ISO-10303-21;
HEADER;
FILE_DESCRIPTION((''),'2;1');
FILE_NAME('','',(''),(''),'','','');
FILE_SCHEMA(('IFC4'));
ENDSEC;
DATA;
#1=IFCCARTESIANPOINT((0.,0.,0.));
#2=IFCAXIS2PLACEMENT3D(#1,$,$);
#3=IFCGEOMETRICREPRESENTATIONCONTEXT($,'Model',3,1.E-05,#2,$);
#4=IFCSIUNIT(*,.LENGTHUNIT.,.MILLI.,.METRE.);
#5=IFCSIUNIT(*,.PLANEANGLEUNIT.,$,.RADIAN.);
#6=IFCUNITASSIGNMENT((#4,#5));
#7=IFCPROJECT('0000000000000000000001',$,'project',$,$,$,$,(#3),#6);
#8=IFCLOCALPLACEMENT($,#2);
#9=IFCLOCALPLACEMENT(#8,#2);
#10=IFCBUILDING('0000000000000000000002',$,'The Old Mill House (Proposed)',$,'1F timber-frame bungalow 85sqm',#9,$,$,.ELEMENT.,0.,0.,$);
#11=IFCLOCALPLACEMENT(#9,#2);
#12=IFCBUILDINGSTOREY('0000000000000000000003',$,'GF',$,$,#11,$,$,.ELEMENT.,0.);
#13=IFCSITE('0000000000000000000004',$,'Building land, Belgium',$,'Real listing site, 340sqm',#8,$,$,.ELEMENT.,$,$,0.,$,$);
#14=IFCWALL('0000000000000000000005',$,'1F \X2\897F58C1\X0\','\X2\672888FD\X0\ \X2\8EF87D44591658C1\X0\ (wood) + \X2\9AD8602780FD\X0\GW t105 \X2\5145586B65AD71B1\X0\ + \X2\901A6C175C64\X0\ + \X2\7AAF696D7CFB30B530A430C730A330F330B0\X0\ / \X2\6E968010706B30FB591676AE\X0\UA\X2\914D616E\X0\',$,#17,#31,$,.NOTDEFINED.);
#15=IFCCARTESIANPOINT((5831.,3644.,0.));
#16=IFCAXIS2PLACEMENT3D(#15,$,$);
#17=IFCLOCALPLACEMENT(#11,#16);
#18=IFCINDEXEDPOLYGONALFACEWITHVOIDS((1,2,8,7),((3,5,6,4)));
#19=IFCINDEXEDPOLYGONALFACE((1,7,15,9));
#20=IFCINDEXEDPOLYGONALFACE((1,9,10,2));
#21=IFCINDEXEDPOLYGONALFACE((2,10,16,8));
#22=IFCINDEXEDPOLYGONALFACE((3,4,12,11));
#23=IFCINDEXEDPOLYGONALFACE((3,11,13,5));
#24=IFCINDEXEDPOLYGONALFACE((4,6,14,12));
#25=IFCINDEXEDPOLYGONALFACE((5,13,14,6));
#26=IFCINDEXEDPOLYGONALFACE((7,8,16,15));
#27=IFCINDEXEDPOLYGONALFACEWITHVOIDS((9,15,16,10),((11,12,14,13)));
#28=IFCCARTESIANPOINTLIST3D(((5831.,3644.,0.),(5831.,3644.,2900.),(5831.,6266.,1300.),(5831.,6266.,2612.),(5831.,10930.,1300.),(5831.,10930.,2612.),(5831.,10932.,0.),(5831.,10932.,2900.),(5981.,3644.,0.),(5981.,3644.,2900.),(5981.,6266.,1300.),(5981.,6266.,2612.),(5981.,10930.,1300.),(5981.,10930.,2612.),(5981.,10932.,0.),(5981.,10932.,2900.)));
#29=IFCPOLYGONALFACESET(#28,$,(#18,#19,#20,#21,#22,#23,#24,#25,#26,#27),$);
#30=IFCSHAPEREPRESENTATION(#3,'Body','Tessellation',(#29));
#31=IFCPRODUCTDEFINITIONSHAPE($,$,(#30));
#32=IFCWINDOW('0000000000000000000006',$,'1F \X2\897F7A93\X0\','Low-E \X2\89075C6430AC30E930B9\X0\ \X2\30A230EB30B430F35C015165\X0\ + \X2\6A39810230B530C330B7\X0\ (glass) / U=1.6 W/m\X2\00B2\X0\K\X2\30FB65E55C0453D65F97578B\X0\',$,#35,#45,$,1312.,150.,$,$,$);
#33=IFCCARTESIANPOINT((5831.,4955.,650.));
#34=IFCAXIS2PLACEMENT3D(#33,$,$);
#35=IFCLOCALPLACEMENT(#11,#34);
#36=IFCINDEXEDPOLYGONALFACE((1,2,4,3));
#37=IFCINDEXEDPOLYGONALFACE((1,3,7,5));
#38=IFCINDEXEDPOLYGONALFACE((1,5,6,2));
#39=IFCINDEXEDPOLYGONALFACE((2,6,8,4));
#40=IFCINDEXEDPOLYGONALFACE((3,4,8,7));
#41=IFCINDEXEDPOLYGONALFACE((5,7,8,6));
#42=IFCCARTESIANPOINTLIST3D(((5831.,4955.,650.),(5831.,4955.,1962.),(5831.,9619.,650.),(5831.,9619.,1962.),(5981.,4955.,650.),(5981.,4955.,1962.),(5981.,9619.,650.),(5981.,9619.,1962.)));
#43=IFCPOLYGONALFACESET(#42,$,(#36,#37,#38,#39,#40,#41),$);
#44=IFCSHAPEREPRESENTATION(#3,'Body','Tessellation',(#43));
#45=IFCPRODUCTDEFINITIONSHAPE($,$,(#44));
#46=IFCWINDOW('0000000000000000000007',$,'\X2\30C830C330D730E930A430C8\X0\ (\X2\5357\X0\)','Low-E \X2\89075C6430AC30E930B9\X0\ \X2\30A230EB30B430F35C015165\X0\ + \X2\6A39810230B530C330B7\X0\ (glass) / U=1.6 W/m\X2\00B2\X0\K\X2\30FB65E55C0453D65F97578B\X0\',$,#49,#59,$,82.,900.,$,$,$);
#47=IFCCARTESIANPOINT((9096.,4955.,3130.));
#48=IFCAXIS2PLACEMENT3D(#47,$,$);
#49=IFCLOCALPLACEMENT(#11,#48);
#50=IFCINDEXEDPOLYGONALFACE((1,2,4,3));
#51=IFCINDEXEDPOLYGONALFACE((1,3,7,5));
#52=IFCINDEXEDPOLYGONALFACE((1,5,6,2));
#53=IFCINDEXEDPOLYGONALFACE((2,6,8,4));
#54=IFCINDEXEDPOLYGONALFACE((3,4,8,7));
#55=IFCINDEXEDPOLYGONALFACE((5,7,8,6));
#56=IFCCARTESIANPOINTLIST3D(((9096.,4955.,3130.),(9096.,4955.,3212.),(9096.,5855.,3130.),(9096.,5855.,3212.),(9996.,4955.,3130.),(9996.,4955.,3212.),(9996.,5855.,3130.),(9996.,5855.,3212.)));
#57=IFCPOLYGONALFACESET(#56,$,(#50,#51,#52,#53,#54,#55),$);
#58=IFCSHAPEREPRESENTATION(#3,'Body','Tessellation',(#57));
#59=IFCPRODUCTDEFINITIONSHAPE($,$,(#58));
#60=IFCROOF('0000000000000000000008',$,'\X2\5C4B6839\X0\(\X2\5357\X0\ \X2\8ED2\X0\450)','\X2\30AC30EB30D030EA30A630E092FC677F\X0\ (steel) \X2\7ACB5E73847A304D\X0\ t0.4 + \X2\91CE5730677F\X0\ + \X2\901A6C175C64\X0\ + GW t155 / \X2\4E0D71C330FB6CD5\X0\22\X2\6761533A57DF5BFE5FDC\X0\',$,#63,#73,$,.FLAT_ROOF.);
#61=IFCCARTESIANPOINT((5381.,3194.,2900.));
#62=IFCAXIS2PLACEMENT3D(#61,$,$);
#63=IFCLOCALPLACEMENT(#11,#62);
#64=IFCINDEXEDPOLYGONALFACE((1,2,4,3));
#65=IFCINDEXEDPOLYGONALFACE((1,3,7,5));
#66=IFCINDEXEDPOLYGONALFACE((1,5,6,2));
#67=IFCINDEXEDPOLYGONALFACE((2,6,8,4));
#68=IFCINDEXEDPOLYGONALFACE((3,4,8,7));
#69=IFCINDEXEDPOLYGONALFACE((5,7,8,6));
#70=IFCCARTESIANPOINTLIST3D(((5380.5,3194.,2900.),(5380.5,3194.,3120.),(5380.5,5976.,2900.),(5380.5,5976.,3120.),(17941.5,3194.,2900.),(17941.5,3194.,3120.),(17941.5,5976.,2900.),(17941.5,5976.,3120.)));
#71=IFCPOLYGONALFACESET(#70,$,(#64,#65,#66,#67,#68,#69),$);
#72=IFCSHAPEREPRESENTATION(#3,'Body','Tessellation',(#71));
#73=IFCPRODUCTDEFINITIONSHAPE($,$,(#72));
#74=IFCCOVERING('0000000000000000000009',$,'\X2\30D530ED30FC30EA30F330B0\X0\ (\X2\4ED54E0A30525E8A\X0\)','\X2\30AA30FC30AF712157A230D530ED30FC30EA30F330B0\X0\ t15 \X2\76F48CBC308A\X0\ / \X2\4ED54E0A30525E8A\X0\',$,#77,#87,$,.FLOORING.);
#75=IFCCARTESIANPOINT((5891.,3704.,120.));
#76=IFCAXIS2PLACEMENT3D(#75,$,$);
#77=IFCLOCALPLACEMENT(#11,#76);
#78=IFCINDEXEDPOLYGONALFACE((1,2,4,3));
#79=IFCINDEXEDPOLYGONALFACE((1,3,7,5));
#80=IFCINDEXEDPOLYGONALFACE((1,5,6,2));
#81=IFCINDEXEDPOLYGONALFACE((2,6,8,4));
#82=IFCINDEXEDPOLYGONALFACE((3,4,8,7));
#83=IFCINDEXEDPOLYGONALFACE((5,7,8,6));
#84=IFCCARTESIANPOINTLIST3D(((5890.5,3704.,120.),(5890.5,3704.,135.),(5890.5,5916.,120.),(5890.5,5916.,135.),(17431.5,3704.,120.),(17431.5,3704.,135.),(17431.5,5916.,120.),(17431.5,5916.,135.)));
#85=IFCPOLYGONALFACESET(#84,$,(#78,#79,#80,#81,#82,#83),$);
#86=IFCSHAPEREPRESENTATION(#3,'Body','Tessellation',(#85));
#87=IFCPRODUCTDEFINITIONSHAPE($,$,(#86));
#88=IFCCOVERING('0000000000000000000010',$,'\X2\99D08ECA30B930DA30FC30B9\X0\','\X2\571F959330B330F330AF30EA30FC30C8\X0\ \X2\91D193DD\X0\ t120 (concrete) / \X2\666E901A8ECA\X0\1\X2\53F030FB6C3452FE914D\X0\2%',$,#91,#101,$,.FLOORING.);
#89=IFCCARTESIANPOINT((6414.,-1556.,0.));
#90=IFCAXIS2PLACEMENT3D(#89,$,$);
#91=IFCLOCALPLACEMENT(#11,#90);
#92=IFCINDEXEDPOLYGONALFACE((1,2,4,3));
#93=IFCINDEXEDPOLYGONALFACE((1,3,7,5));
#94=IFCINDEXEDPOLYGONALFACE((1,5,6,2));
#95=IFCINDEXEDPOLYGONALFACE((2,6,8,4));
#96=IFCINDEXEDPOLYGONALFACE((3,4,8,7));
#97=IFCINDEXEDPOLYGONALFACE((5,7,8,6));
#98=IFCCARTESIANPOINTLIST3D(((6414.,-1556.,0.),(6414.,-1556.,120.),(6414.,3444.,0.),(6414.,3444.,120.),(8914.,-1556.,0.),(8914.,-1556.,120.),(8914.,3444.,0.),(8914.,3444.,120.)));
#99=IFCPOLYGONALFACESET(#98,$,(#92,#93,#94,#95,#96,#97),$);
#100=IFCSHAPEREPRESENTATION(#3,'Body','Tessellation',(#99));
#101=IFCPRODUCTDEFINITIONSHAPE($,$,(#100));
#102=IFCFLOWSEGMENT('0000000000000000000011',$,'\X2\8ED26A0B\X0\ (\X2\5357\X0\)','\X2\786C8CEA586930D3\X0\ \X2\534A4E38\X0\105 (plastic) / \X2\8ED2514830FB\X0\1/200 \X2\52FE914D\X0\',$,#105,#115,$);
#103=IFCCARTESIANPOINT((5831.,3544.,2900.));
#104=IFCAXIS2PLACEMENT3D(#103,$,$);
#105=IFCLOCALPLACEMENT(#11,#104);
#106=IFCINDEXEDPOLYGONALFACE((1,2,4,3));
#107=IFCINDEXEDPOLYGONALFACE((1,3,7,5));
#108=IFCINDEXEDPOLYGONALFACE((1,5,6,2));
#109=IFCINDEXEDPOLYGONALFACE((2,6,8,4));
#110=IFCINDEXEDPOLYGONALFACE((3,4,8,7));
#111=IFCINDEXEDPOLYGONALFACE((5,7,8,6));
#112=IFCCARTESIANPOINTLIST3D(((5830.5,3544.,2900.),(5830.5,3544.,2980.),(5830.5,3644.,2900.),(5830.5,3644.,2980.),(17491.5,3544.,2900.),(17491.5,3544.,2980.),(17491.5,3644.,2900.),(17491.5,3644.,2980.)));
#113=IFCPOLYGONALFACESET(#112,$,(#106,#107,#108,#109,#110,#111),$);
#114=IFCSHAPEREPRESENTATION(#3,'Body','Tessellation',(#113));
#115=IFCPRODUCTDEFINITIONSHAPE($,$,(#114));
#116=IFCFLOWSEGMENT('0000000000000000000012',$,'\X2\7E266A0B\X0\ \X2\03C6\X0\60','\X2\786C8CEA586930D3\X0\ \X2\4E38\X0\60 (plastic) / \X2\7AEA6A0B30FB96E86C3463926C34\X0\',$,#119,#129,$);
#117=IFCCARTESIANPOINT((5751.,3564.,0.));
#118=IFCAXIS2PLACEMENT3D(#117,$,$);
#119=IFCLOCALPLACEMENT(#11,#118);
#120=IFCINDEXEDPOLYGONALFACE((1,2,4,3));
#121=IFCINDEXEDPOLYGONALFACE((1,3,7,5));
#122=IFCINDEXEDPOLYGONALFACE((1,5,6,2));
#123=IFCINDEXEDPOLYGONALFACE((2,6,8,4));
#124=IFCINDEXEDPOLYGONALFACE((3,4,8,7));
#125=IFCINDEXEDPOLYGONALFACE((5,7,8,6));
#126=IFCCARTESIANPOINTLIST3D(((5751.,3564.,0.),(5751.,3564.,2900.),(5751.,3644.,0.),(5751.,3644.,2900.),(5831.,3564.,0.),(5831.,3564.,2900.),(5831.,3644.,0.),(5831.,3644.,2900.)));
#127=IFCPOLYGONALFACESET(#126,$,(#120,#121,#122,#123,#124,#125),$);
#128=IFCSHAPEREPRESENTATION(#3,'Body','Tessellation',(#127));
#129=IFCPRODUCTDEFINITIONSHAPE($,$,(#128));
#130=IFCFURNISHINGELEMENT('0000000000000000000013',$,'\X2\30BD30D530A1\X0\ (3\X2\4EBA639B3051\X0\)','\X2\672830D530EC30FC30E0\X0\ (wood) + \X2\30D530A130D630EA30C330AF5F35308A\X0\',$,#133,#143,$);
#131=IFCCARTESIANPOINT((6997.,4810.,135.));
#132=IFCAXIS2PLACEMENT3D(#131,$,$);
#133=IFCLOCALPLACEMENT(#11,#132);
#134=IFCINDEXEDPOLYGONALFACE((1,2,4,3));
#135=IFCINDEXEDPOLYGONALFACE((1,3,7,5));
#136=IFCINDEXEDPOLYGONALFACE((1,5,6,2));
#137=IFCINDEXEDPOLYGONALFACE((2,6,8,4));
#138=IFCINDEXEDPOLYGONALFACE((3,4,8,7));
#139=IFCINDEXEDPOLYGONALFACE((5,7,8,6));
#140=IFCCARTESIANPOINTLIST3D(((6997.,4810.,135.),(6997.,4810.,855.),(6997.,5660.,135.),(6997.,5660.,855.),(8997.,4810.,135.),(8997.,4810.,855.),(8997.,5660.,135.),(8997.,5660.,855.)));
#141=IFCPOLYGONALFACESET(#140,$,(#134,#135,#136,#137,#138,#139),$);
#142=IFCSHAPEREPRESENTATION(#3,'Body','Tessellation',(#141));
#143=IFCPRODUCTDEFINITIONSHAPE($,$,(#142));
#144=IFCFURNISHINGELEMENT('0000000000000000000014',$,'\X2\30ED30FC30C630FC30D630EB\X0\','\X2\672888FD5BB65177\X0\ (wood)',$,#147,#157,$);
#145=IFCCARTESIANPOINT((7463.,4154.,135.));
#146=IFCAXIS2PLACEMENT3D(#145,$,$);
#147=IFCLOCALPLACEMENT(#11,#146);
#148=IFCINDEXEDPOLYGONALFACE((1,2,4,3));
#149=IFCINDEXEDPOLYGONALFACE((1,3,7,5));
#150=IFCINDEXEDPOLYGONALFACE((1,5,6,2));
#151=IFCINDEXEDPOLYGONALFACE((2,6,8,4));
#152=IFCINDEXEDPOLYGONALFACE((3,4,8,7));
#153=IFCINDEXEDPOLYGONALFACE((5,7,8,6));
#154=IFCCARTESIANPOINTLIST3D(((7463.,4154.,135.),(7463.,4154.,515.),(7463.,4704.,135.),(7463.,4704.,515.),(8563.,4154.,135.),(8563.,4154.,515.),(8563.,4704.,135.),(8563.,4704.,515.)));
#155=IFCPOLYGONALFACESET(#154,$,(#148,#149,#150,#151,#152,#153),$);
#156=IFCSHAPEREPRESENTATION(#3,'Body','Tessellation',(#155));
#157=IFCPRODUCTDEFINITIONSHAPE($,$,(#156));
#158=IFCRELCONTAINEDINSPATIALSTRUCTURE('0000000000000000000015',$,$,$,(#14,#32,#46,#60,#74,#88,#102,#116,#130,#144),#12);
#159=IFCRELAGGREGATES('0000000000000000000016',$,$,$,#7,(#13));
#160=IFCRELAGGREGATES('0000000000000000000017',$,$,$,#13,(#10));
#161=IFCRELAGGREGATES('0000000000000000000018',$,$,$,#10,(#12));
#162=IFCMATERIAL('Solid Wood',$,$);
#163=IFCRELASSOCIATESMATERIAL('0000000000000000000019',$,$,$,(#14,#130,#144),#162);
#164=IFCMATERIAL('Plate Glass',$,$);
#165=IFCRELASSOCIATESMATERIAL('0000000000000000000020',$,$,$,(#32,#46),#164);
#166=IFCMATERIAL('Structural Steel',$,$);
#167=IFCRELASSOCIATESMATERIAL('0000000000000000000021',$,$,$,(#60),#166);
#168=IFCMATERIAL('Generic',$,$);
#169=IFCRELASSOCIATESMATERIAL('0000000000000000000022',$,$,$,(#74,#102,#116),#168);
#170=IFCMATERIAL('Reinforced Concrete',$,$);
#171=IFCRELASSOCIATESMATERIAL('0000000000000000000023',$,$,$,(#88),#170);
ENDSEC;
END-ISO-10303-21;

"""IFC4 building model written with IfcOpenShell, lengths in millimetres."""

from ifc_helpers import new_model, si_unit, frame, frame_2d, origin, place, context, project, spatial, rectangle, extrude, material, element, fill, save


model = new_model("IFC4")

# Units and contexts
model_context = context("Model", 3, precision=1e-05, world=origin())
ifc_project = project(units=[si_unit("LENGTHUNIT", "METRE", prefix="MILLI"), si_unit("PLANEANGLEUNIT", "RADIAN")], contexts=[model_context])

# Site, building, storey
site_placement = place(None, origin())
site = spatial("IfcSite", under=ifc_project, at=site_placement, Name="Building land, Belgium", ObjectType="Real listing site, 340sqm", CompositionType="ELEMENT", RefElevation=0.0)
building_placement = place(site_placement, origin())
building = spatial("IfcBuilding", under=site, at=building_placement, Name="The Old Mill House (Proposed)", ObjectType="1F timber-frame bungalow 85sqm", CompositionType="ELEMENT", ElevationOfRefHeight=0.0, ElevationOfTerrain=0.0)
storey_placement = place(building_placement, origin())
storey = spatial("IfcBuildingStorey", under=building, at=storey_placement, Name="GF", CompositionType="ELEMENT", Elevation=0.0)

# Shared definitions
ifc_material_1 = material(Name="Solid Wood")

# Shared definitions
ifc_material_2 = material(Name="Reinforced Concrete")

# Shared definitions
ifc_material_3 = material(Name="Plate Glass")

# Wall, opening, window
wall_1_placement = place(storey_placement, frame((5831.0, 3644.0, 0.0)))
wall_1 = element("IfcWall", 1, at=wall_1_placement, inside=storey, material=ifc_material_1, Name="1F 西壁", Description="木製 軸組外壁 (wood) + 高性能GW t105 充填断熱 + 通気層 + 窯業系サイディング / 準耐火・外皮UA配慮", PredefinedType="NOTDEFINED", context=model_context, shape_type="SweptSolid", body=[
    extrude(rectangle(XDim=150.0, YDim=7288.0, at=frame_2d((75.0, 3644.0))), frame((5831.0, 3644.0, 0.0)), (0.0, 0.0, 1.0), 2900.0),
])
opening_1_placement = place(storey_placement, frame((5831.0, 4955.0, 650.0)))
opening_1 = element("IfcOpeningElement", 2, at=opening_1_placement, cuts=wall_1, PredefinedType="NOTDEFINED", context=model_context, shape_type="SweptSolid", body=[
    extrude(rectangle(XDim=150.0, YDim=4664.0, at=frame_2d((75.0, 2332.0))), frame((5831.0, 4955.0, 650.0)), (0.0, 0.0, 1.0), 1312.0),
])
window_1_placement = place(storey_placement, frame((5831.0, 4955.0, 650.0)))
window_1 = element("IfcWindow", 3, at=window_1_placement, inside=storey, material=ifc_material_3, Name="1F 西窓", Description="Low-E 複層ガラス アルゴン封入 + 樹脂サッシ (glass) / U=1.6 W/m²K・日射取得型", OverallHeight=1312.0, OverallWidth=150.0, context=model_context, shape_type="SweptSolid", body=[
    extrude(rectangle(XDim=150.0, YDim=4664.0, at=frame_2d((75.0, 2332.0))), frame((5831.0, 4955.0, 650.0)), (0.0, 0.0, 1.0), 1312.0),
])
fill(opening_1, window_1)

# Window
window_2_placement = place(storey_placement, frame((9096.0, 4955.0, 3130.0)))
element("IfcWindow", 4, at=window_2_placement, inside=storey, material=ifc_material_3, Name="トップライト (南)", Description="Low-E 複層ガラス アルゴン封入 + 樹脂サッシ (glass) / U=1.6 W/m²K・日射取得型", OverallHeight=82.0, OverallWidth=900.0, context=model_context, shape_type="SweptSolid", body=[
    extrude(rectangle(XDim=900.0, YDim=900.0, at=frame_2d((450.0, 450.0))), frame((9096.0, 4955.0, 3130.0)), (0.0, 0.0, 1.0), 82.0),
])

# Roof
ifc_material_4 = material(Name="Structural Steel")
roof_1_placement = place(storey_placement, frame((5381.0, 3194.0, 2900.0)))
element("IfcRoof", 5, at=roof_1_placement, inside=storey, material=ifc_material_4, Name="屋根(南 軒450)", Description="ガルバリウム鋼板 (steel) 立平葺き t0.4 + 野地板 + 通気層 + GW t155 / 不燃・法22条区域対応", PredefinedType="FLAT_ROOF", context=model_context, shape_type="SweptSolid", body=[
    extrude(rectangle(XDim=12561.0, YDim=2782.0, at=frame_2d((6280.0, 1391.0))), frame((5381.0, 3194.0, 2900.0)), (0.0, 0.0, 1.0), 220.0),
])

# Coverings
ifc_material_5 = material(Name="Generic")
covering_1_placement = place(storey_placement, frame((5891.0, 3704.0, 120.0)))
element("IfcCovering", 6, at=covering_1_placement, inside=storey, material=ifc_material_5, Name="フローリング (仕上げ床)", Description="オーク無垢フローリング t15 直貼り / 仕上げ床", PredefinedType="FLOORING", context=model_context, shape_type="SweptSolid", body=[
    extrude(rectangle(XDim=11541.0, YDim=2212.0, at=frame_2d((5770.0, 1106.0))), frame((5891.0, 3704.0, 120.0)), (0.0, 0.0, 1.0), 15.0),
])
covering_2_placement = place(storey_placement, frame((6414.0, -1556.0, 0.0)))
element("IfcCovering", 7, at=covering_2_placement, inside=storey, material=ifc_material_2, Name="駐車スペース", Description="土間コンクリート 金鏝 t120 (concrete) / 普通車1台・水勾配2%", PredefinedType="FLOORING", context=model_context, shape_type="SweptSolid", body=[
    extrude(rectangle(XDim=2500.0, YDim=5000.0, at=frame_2d((1250.0, 2500.0))), frame((6414.0, -1556.0, 0.0)), (0.0, 0.0, 1.0), 120.0),
])

# Flow segments
flow_segment_1_placement = place(storey_placement, frame((5831.0, 3544.0, 2900.0)))
element("IfcFlowSegment", 8, at=flow_segment_1_placement, inside=storey, material=ifc_material_5, Name="軒樋 (南)", Description="硬質塩ビ 半丸105 (plastic) / 軒先・1/200 勾配", context=model_context, shape_type="SweptSolid", body=[
    extrude(rectangle(XDim=11661.0, YDim=100.0, at=frame_2d((5830.0, 50.0))), frame((5831.0, 3544.0, 2900.0)), (0.0, 0.0, 1.0), 80.0),
])
flow_segment_2_placement = place(storey_placement, frame((5751.0, 3564.0, 0.0)))
element("IfcFlowSegment", 9, at=flow_segment_2_placement, inside=storey, material=ifc_material_5, Name="縦樋 φ60", Description="硬質塩ビ 丸60 (plastic) / 竪樋・雨水排水", context=model_context, shape_type="SweptSolid", body=[
    extrude(rectangle(XDim=80.0, YDim=80.0, at=frame_2d((40.0, 40.0))), frame((5751.0, 3564.0, 0.0)), (0.0, 0.0, 1.0), 2900.0),
])

# Furnishing elements
furnishing_1_placement = place(storey_placement, frame((6997.0, 4810.0, 135.0)))
element("IfcFurnishingElement", 10, at=furnishing_1_placement, inside=storey, material=ifc_material_1, Name="ソファ (3人掛け)", Description="木フレーム (wood) + ファブリック張り", context=model_context, shape_type="SweptSolid", body=[
    extrude(rectangle(XDim=2000.0, YDim=850.0, at=frame_2d((1000.0, 425.0))), frame((6997.0, 4810.0, 135.0)), (0.0, 0.0, 1.0), 720.0),
])
furnishing_2_placement = place(storey_placement, frame((7463.0, 4154.0, 135.0)))
element("IfcFurnishingElement", 11, at=furnishing_2_placement, inside=storey, material=ifc_material_1, Name="ローテーブル", Description="木製家具 (wood)", context=model_context, shape_type="SweptSolid", body=[
    extrude(rectangle(XDim=1100.0, YDim=550.0, at=frame_2d((550.0, 275.0))), frame((7463.0, 4154.0, 135.0)), (0.0, 0.0, 1.0), 380.0),
])

save(model, "model.ifc")
